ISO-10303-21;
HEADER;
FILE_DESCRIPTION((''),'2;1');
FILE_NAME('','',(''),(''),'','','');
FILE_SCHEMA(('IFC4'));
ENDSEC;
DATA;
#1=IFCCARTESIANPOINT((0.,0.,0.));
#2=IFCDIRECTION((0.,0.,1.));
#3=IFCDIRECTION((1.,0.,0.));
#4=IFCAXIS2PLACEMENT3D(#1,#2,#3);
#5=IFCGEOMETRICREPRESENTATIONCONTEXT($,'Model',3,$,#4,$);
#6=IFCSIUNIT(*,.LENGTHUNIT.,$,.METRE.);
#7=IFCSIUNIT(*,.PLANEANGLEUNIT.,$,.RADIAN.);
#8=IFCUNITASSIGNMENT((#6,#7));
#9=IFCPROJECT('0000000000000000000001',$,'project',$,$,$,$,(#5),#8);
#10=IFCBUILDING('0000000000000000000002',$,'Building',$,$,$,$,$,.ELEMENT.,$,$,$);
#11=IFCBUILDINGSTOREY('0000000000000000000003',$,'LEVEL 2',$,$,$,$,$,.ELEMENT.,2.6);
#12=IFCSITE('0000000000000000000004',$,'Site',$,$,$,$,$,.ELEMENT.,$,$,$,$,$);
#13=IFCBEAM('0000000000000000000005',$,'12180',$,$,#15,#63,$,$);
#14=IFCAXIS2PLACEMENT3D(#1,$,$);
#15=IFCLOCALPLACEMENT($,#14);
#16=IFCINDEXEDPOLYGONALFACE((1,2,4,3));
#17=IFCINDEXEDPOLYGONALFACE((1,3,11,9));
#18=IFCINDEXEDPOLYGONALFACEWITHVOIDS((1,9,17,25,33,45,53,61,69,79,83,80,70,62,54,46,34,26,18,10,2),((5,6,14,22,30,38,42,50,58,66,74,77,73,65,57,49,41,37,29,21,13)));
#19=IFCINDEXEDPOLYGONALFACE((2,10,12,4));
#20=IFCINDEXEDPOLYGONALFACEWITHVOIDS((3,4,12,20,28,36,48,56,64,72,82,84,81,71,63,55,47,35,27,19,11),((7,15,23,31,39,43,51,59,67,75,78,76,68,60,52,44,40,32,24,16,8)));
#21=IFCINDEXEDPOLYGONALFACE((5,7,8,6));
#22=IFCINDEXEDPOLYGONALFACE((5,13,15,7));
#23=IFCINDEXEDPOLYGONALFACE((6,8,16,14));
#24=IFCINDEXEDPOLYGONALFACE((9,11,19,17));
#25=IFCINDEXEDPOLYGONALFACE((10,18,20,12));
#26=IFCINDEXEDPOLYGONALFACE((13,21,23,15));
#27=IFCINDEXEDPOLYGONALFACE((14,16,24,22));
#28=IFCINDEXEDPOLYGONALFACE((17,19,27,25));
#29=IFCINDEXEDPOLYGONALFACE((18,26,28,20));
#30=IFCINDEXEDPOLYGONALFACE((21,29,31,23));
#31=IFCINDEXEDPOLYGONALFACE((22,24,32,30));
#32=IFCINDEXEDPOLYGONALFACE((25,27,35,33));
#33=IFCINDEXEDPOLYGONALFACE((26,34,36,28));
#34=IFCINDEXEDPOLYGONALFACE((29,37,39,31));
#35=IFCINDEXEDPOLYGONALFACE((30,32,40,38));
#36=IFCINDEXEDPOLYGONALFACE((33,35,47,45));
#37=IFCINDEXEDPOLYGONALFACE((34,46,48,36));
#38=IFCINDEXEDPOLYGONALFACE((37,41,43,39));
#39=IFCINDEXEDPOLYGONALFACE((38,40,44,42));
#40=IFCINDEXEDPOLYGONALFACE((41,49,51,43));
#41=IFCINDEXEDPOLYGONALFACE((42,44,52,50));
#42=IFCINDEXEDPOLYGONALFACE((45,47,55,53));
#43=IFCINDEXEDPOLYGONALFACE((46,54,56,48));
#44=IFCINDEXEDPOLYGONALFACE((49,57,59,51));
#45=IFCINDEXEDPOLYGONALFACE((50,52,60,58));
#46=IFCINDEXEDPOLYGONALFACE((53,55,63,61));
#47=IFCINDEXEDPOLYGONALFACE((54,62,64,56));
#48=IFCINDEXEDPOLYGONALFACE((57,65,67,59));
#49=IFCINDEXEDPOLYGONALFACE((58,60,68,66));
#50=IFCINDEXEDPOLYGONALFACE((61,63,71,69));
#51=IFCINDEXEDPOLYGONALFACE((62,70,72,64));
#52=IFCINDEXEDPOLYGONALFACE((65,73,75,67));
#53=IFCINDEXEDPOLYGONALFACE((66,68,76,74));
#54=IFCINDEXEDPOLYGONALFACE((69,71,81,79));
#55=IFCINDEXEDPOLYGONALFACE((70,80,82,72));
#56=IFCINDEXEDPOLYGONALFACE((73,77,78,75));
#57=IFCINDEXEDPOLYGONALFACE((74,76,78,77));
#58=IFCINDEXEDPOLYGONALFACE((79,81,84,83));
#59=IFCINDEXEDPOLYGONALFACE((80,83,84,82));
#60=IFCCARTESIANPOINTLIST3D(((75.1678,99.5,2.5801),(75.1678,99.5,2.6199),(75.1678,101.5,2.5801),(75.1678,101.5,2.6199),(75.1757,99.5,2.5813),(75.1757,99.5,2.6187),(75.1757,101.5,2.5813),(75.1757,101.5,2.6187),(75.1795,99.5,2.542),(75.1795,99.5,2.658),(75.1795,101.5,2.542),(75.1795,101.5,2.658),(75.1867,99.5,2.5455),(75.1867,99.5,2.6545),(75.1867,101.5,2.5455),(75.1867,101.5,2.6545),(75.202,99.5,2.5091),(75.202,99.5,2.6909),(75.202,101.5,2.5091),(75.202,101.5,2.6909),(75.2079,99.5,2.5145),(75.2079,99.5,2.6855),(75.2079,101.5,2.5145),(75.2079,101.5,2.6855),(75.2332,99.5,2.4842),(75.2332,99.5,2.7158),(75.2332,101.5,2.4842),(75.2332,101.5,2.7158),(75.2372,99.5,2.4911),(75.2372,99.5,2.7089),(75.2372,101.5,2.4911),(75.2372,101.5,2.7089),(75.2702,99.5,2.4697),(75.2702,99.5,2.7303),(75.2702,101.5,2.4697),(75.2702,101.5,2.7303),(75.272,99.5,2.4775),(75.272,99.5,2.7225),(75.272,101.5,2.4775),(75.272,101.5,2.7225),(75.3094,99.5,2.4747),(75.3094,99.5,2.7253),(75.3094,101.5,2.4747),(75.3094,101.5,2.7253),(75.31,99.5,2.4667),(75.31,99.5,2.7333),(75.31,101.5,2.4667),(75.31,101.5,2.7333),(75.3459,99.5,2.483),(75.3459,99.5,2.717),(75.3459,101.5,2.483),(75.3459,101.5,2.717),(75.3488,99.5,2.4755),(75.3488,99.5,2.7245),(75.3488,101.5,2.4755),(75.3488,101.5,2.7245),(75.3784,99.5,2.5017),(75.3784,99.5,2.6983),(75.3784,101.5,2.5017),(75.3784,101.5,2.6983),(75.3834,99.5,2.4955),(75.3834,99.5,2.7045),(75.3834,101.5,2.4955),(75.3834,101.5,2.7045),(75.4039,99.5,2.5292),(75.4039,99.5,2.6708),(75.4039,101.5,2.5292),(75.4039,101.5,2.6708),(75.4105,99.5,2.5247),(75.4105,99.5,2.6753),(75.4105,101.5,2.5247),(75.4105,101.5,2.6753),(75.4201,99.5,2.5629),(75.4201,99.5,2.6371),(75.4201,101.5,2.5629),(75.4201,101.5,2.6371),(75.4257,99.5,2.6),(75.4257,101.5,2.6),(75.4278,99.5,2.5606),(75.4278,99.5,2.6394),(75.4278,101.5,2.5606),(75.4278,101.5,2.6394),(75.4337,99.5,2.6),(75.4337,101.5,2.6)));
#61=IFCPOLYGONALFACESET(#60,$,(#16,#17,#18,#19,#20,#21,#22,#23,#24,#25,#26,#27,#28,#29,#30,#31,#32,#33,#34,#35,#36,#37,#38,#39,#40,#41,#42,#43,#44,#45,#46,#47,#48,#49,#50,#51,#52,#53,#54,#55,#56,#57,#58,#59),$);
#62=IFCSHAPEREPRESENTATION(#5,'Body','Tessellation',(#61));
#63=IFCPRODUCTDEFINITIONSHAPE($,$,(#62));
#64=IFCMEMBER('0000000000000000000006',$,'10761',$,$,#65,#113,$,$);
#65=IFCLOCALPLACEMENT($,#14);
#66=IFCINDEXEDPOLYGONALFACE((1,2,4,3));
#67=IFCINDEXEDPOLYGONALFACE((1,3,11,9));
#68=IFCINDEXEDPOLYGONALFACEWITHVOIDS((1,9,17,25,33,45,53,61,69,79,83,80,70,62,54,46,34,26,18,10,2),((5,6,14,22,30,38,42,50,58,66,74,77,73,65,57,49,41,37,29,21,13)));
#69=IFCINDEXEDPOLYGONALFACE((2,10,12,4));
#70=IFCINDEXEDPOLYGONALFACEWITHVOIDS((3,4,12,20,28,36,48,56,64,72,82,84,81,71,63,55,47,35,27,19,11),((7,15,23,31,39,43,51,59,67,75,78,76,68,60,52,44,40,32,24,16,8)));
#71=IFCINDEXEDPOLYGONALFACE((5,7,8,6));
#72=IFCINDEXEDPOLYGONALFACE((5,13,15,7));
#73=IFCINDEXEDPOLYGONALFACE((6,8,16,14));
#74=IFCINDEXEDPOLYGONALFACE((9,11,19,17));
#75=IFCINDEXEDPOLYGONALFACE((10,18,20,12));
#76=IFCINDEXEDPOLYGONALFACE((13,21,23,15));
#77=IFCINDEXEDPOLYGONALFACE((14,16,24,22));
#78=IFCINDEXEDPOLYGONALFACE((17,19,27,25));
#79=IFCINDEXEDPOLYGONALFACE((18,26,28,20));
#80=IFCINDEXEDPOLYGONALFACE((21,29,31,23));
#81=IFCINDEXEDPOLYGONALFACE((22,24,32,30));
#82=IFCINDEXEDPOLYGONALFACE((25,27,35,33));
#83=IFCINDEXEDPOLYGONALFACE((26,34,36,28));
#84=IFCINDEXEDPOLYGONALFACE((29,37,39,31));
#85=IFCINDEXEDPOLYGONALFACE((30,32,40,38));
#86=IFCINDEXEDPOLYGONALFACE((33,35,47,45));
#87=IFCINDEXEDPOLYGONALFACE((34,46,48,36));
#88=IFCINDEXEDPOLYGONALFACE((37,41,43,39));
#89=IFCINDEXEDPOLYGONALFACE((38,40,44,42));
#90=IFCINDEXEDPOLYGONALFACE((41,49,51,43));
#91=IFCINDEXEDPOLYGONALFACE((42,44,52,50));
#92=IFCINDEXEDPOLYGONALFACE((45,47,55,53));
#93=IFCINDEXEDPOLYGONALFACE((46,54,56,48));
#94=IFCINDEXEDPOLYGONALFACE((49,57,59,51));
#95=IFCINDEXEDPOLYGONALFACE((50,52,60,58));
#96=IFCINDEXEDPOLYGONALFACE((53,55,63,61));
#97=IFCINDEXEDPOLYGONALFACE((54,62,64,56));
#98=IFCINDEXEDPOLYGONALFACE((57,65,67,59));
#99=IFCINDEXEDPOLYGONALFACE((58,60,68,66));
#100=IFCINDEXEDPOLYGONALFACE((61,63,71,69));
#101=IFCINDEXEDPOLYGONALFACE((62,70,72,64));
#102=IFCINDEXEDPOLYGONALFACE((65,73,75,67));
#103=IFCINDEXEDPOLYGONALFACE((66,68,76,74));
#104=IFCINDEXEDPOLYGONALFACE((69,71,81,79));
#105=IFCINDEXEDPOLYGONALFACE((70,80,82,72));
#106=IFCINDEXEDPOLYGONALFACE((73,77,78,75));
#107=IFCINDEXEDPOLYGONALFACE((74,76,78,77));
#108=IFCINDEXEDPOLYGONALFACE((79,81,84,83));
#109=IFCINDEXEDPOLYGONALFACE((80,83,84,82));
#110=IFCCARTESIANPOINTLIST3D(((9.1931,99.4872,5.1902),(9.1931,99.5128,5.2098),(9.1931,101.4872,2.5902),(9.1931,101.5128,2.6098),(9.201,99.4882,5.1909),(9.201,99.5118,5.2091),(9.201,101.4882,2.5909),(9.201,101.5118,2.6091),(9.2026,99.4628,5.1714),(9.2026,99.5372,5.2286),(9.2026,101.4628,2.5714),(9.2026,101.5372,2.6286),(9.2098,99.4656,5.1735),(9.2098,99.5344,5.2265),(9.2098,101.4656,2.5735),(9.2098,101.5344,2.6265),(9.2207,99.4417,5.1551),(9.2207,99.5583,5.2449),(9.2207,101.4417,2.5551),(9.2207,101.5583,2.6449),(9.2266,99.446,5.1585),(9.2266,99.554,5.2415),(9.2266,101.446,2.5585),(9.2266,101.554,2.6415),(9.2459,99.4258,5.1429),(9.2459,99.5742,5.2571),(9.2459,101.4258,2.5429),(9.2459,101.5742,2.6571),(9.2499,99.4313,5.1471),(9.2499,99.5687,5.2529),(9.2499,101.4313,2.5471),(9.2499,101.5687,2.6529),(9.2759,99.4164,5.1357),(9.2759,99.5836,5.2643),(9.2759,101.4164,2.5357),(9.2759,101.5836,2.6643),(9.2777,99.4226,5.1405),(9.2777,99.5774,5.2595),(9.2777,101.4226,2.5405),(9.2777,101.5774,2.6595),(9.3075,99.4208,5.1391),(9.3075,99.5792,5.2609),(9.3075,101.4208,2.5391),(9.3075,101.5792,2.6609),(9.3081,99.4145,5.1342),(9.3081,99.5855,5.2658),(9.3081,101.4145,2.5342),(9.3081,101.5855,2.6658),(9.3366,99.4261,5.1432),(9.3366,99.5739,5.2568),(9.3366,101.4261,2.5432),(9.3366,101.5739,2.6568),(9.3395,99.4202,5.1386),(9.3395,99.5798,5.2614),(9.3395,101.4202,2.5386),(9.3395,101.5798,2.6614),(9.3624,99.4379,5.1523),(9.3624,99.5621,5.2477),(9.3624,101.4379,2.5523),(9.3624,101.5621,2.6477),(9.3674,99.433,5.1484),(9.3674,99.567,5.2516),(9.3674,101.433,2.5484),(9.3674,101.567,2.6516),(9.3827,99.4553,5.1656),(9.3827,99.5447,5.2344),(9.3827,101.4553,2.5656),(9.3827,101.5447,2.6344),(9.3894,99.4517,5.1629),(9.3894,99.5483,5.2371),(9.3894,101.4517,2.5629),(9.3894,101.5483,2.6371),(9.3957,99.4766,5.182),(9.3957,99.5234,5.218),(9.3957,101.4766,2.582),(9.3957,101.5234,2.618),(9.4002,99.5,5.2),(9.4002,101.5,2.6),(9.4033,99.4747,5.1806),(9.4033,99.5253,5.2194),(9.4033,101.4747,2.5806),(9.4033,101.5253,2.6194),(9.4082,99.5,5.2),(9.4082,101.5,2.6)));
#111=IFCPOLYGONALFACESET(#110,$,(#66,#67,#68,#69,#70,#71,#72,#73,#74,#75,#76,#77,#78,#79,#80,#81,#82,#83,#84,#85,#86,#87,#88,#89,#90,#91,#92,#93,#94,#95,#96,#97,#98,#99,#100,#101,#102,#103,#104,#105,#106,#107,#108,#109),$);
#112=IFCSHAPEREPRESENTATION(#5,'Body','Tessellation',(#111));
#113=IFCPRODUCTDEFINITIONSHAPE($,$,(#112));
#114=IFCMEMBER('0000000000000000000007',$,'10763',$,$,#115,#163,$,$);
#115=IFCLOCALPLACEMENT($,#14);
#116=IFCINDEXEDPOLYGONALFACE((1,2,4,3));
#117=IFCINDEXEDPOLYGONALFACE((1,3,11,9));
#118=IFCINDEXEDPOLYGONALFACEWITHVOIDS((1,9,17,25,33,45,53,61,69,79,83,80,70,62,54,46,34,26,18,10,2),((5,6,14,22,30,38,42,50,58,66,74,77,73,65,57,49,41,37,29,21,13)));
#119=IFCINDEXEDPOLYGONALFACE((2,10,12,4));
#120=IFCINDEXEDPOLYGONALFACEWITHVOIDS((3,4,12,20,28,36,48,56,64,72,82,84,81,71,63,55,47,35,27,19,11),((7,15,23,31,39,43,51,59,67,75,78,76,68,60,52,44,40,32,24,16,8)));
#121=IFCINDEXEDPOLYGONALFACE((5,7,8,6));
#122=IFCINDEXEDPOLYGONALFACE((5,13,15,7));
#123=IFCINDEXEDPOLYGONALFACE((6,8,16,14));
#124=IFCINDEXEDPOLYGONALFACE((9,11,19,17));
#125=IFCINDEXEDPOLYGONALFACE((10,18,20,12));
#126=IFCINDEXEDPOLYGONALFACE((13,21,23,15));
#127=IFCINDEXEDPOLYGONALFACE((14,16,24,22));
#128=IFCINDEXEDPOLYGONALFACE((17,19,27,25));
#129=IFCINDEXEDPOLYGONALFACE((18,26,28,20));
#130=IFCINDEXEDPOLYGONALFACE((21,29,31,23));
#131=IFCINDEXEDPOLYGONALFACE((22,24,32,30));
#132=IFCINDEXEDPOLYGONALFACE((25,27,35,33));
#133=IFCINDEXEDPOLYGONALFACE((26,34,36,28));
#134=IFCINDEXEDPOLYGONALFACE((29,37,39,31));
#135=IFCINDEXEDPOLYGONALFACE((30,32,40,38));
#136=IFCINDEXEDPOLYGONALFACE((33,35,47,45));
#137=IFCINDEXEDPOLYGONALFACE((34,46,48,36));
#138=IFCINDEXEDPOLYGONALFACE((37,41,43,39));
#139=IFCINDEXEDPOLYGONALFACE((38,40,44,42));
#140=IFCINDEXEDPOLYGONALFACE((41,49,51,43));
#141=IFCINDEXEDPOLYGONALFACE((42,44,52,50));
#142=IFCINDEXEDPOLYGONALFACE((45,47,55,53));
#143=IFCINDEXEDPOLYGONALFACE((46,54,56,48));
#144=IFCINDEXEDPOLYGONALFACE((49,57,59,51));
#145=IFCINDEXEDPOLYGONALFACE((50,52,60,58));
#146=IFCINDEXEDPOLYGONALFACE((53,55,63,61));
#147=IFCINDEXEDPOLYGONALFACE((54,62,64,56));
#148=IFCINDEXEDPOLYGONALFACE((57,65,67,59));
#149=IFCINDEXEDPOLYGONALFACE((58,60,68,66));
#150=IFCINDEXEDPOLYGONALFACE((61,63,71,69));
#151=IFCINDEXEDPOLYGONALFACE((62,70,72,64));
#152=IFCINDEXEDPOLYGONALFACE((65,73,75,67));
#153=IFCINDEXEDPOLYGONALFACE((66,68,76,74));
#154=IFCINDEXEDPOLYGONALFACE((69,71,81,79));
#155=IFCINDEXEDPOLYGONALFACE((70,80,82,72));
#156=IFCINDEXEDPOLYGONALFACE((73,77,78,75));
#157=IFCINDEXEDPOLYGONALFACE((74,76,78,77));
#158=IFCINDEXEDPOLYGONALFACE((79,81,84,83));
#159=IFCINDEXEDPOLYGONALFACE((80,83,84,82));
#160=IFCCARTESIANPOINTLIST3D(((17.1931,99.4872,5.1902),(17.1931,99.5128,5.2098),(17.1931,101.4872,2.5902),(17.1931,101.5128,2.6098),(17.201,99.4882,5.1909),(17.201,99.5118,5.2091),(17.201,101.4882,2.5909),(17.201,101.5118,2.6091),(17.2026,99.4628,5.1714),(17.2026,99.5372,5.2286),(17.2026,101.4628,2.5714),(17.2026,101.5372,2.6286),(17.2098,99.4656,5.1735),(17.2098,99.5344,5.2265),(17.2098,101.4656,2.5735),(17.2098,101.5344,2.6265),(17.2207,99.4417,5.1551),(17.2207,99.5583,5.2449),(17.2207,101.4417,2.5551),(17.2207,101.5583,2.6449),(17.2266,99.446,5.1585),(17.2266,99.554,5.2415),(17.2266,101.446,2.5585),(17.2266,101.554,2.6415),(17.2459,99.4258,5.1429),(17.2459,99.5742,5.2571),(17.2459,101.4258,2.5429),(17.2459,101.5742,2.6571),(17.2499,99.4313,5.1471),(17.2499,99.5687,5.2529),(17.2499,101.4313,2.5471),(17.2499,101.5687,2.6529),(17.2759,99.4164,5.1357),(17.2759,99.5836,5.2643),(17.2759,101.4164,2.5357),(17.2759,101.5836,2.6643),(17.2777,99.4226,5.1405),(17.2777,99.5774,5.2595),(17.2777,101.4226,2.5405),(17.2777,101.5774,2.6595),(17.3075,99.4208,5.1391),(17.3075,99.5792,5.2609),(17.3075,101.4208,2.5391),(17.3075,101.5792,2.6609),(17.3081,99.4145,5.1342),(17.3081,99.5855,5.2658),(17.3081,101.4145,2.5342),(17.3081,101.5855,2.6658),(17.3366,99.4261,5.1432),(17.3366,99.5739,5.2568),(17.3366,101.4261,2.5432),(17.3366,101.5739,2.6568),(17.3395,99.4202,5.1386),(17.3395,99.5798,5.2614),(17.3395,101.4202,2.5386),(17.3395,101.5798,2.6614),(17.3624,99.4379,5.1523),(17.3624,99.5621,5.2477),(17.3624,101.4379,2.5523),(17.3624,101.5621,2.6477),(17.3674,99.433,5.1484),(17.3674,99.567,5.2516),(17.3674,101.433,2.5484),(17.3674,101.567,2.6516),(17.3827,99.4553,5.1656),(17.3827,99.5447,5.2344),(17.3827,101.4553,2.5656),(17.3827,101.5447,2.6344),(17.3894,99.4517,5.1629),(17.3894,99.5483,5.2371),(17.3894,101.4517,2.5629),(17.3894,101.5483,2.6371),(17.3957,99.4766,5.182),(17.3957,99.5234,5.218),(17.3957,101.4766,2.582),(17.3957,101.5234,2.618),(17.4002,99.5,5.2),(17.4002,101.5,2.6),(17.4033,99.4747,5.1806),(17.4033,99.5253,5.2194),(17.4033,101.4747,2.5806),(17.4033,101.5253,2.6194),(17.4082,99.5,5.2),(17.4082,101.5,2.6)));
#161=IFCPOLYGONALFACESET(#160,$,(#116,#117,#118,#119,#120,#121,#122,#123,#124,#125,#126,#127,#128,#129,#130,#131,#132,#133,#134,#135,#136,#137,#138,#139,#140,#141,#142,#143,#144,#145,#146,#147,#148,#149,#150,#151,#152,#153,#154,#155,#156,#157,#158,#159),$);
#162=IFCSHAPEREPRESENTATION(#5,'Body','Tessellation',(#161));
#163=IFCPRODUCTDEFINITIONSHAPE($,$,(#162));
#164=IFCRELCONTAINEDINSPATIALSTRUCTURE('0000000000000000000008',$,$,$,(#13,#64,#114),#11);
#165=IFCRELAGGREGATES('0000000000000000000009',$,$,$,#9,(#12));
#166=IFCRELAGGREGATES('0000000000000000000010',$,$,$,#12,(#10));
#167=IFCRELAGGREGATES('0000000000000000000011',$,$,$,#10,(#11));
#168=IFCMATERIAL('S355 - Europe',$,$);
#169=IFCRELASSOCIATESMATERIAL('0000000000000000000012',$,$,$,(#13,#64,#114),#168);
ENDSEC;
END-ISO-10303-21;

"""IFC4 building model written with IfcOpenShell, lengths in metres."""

from ifc_helpers import new_model, si_unit, frame, origin_with_axes, origin_2d_with_axis, place, context, project, spatial, hollow_circle, extrude, material, material_profile, profile_set, profile_usage, element, save


model = new_model("IFC4")

# Units and contexts
model_context = context("Model", 3, world=origin_with_axes())
ifc_project = project(units=[si_unit("LENGTHUNIT", "METRE"), si_unit("PLANEANGLEUNIT", "RADIAN")], contexts=[model_context])

# Site, building, storey
site = spatial("IfcSite", under=ifc_project, Name="Site", CompositionType="ELEMENT")
building = spatial("IfcBuilding", under=site, Name="Building", CompositionType="ELEMENT")
storey = spatial("IfcBuildingStorey", under=building, Name="LEVEL 2", CompositionType="ELEMENT", Elevation=2.6)

# Shared definitions
ifc_material = material(Name="S355 - Europe")

# Beam
ifc_material_profile_1 = material_profile(ifc_material, hollow_circle(Radius=0.1337, WallThickness=0.008, at=origin_2d_with_axis()))
ifc_profile_set_1 = profile_set([ifc_material_profile_1])
ifc_profile_usage_1 = profile_usage(ifc_profile_set_1, cardinal=10)
beam_1_placement = place(None, frame((75.3, 101.5, 2.6), z_axis=(0.0, -1.0, 0.0), x_axis=(1.0, 0.0, 0.0)))
element("IfcBeam", 1, at=beam_1_placement, inside=storey, material=ifc_profile_usage_1, Name="12180", context=model_context, shape_type="SweptSolid", body=[
    extrude(hollow_circle(Radius=0.1337, WallThickness=0.008, at=origin_2d_with_axis()), origin_with_axes(), (0.0, 0.0, 1.0), 2.0),
])

# Members
ifc_material_profile_2 = material_profile(ifc_material, hollow_circle(Radius=0.1081, WallThickness=0.008, at=origin_2d_with_axis()))
ifc_profile_set_2 = profile_set([ifc_material_profile_2])
ifc_profile_usage_2 = profile_usage(ifc_profile_set_2, cardinal=10)
member_1_placement = place(None, frame((9.3, 101.5, 2.6), z_axis=(0.0, -0.609711, 0.792624), x_axis=(1.0, 0.0, 0.0)))
element("IfcMember", 2, at=member_1_placement, inside=storey, material=ifc_profile_usage_2, Name="10761", context=model_context, shape_type="SweptSolid", body=[
    extrude(hollow_circle(Radius=0.1081, WallThickness=0.008, at=origin_2d_with_axis()), origin_with_axes(), (0.0, 0.0, 1.0), 3.2802),
])
ifc_material_profile_3 = material_profile(ifc_material, hollow_circle(Radius=0.1081, WallThickness=0.008, at=origin_2d_with_axis()))
ifc_profile_set_3 = profile_set([ifc_material_profile_3])
ifc_profile_usage_3 = profile_usage(ifc_profile_set_3, cardinal=10)
member_2_placement = place(None, frame((17.3, 101.5, 2.6), z_axis=(0.0, -0.609711, 0.792624), x_axis=(1.0, 0.0, 0.0)))
element("IfcMember", 3, at=member_2_placement, inside=storey, material=ifc_profile_usage_3, Name="10763", context=model_context, shape_type="SweptSolid", body=[
    extrude(hollow_circle(Radius=0.1081, WallThickness=0.008, at=origin_2d_with_axis()), origin_with_axes(), (0.0, 0.0, 1.0), 3.2802),
])

save(model, "model.ifc")
